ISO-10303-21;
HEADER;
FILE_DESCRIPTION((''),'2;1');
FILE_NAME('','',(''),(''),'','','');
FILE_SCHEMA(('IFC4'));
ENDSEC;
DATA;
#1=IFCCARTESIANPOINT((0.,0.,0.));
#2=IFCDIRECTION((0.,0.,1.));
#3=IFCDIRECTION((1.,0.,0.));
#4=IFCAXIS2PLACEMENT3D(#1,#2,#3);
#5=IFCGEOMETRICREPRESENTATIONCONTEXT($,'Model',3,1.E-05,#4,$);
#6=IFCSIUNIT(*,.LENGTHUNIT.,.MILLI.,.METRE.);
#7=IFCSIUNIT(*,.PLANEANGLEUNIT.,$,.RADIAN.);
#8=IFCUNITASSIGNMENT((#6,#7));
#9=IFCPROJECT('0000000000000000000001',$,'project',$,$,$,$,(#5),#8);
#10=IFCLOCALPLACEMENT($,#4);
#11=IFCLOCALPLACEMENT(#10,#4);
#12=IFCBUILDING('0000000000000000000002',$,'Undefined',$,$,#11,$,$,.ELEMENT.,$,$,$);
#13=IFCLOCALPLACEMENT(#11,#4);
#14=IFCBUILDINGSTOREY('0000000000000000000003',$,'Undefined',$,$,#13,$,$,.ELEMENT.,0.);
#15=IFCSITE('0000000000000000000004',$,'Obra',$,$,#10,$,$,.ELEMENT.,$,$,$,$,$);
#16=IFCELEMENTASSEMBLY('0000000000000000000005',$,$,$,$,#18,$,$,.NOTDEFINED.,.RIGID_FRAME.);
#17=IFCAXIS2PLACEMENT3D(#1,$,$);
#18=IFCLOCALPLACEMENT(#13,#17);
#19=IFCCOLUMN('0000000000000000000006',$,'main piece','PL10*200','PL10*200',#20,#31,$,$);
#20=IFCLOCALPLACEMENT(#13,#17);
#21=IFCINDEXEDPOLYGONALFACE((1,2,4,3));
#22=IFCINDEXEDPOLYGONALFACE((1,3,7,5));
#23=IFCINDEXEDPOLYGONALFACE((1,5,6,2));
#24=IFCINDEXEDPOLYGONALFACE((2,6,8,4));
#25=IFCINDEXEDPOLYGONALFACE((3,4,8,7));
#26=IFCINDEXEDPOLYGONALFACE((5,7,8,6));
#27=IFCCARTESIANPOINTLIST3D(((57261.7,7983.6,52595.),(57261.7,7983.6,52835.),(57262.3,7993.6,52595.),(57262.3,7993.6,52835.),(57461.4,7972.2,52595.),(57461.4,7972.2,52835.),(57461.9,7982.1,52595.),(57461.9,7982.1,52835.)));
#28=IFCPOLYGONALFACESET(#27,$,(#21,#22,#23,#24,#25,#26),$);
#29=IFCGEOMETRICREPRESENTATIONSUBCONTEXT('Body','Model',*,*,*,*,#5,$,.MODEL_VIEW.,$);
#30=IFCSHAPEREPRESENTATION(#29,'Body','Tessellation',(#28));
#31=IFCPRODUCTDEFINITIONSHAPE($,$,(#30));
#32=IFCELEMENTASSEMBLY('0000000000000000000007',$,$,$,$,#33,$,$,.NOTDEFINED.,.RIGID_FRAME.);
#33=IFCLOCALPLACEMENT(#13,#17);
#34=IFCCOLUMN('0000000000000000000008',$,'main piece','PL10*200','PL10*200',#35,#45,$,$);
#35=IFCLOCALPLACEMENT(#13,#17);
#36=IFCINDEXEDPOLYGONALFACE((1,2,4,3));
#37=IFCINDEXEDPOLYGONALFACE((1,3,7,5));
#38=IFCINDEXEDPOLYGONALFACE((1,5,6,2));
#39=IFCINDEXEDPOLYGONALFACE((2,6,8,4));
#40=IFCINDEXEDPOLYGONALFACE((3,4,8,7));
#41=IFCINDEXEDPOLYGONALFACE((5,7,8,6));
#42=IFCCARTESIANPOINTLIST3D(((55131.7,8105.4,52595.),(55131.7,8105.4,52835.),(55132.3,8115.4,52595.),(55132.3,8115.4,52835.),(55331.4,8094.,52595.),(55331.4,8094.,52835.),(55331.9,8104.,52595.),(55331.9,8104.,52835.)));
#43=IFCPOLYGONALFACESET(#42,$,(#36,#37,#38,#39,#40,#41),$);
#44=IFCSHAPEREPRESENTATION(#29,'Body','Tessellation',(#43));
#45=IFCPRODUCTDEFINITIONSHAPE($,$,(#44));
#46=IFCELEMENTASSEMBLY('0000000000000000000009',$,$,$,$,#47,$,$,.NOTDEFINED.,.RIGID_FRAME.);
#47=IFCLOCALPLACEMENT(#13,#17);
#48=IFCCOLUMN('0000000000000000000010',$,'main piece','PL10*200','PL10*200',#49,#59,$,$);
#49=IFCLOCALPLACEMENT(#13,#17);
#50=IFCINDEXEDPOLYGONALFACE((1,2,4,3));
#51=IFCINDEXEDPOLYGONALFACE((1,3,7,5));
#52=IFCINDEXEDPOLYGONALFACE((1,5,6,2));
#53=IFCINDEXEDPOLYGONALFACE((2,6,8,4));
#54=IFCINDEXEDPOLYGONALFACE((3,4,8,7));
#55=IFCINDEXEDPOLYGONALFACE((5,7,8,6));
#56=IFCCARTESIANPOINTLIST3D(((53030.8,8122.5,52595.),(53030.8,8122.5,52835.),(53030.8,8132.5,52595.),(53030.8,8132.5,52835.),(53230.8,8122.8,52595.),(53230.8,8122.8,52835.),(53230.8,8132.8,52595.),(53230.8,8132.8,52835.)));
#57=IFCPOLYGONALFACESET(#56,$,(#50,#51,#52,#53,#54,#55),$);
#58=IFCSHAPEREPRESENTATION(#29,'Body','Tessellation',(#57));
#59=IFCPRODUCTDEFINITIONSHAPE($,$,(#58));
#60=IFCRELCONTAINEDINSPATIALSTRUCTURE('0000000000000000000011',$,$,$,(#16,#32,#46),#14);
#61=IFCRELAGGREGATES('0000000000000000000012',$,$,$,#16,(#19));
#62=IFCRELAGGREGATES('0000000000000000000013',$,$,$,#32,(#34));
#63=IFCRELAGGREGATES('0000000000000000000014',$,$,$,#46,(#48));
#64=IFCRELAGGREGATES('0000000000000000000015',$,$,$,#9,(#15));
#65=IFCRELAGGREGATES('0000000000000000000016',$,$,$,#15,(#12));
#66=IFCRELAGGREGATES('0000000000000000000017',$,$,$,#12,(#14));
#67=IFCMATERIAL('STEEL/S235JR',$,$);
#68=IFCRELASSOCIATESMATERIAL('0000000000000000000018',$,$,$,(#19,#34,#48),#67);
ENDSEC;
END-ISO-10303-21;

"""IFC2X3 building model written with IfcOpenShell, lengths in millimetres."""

from ifc_helpers import new_model, si_unit, frame, origin_with_axes, origin_2d_with_axis, place, context, subcontext, project, spatial, rectangle, extrude, material, element, aggregate, save


model = new_model("IFC2X3")

# Units and contexts
model_context = context("Model", 3, precision=1e-05, world=origin_with_axes())
body_context = subcontext(model_context, "Body", "Model", "MODEL_VIEW")
ifc_project = project(units=[si_unit("LENGTHUNIT", "METRE", prefix="MILLI"), si_unit("PLANEANGLEUNIT", "RADIAN")], contexts=[model_context])

# Site, building, storey
site_placement = place(None, origin_with_axes())
site = spatial("IfcSite", under=ifc_project, at=site_placement, Name="Obra", CompositionType="ELEMENT")
building_placement = place(site_placement, origin_with_axes())
building = spatial("IfcBuilding", under=site, at=building_placement, Name="Undefined", CompositionType="ELEMENT")
storey_placement = place(building_placement, origin_with_axes())
storey = spatial("IfcBuildingStorey", under=building, at=storey_placement, Name="Undefined", CompositionType="ELEMENT", Elevation=0.0)

# Element assemblies, columns
assembly_1_placement = place(storey_placement, origin_with_axes())
assembly_1 = element("IfcElementAssembly", 1, at=assembly_1_placement, inside=storey, AssemblyPlace="NOTDEFINED", PredefinedType="RIGID_FRAME")
ifc_material_1 = material(Name="STEEL/S235JR")
column_1_placement = place(assembly_1_placement, frame((57361.8, 7982.9, 52595.0), z_axis=(0.0, 0.0, 1.0), x_axis=(-0.998368, 0.05711, 0.0)))
column_1 = element("IfcColumn", 2, at=column_1_placement, material=ifc_material_1, Name="main piece", Description="PL10*200", ObjectType="PL10*200", context=body_context, shape_type="SweptSolid", body=[
    extrude(rectangle(XDim=10.0, YDim=200.0, at=origin_2d_with_axis()), frame((0.0, 0.0, 240.0), z_axis=(0.0, 0.0, -1.0), x_axis=(0.0, 1.0, 0.0)), (0.0, 0.0, 1.0), 240.0),
])
assembly_2_placement = place(storey_placement, origin_with_axes())
assembly_2 = element("IfcElementAssembly", 3, at=assembly_2_placement, inside=storey, AssemblyPlace="NOTDEFINED", PredefinedType="RIGID_FRAME")
column_2_placement = place(assembly_2_placement, frame((55231.8, 8104.7, 52595.0), z_axis=(0.0, 0.0, 1.0), x_axis=(-0.998368, 0.05711, 0.0)))
column_2 = element("IfcColumn", 4, at=column_2_placement, material=ifc_material_1, Name="main piece", Description="PL10*200", ObjectType="PL10*200", context=body_context, shape_type="SweptSolid", body=[
    extrude(rectangle(XDim=10.0, YDim=200.0, at=origin_2d_with_axis()), frame((0.0, 0.0, 240.0), z_axis=(0.0, 0.0, -1.0), x_axis=(0.0, 1.0, 0.0)), (0.0, 0.0, 1.0), 240.0),
])
assembly_3_placement = place(storey_placement, origin_with_axes())
assembly_3 = element("IfcElementAssembly", 5, at=assembly_3_placement, inside=storey, AssemblyPlace="NOTDEFINED", PredefinedType="RIGID_FRAME")
column_3_placement = place(assembly_3_placement, frame((53130.8, 8127.7, 52595.0), z_axis=(0.0, 0.0, 1.0), x_axis=(-0.999999, -0.001508, 0.0)))
column_3 = element("IfcColumn", 6, at=column_3_placement, material=ifc_material_1, Name="main piece", Description="PL10*200", ObjectType="PL10*200", context=body_context, shape_type="SweptSolid", body=[
    extrude(rectangle(XDim=10.0, YDim=200.0, at=origin_2d_with_axis()), frame((0.0, 0.0, 240.0), z_axis=(0.0, 0.0, -1.0), x_axis=(0.0, 1.0, 0.0)), (0.0, 0.0, 1.0), 240.0),
])

aggregate(assembly_1, [column_1])
aggregate(assembly_2, [column_2])
aggregate(assembly_3, [column_3])

save(model, "model.ifc")
